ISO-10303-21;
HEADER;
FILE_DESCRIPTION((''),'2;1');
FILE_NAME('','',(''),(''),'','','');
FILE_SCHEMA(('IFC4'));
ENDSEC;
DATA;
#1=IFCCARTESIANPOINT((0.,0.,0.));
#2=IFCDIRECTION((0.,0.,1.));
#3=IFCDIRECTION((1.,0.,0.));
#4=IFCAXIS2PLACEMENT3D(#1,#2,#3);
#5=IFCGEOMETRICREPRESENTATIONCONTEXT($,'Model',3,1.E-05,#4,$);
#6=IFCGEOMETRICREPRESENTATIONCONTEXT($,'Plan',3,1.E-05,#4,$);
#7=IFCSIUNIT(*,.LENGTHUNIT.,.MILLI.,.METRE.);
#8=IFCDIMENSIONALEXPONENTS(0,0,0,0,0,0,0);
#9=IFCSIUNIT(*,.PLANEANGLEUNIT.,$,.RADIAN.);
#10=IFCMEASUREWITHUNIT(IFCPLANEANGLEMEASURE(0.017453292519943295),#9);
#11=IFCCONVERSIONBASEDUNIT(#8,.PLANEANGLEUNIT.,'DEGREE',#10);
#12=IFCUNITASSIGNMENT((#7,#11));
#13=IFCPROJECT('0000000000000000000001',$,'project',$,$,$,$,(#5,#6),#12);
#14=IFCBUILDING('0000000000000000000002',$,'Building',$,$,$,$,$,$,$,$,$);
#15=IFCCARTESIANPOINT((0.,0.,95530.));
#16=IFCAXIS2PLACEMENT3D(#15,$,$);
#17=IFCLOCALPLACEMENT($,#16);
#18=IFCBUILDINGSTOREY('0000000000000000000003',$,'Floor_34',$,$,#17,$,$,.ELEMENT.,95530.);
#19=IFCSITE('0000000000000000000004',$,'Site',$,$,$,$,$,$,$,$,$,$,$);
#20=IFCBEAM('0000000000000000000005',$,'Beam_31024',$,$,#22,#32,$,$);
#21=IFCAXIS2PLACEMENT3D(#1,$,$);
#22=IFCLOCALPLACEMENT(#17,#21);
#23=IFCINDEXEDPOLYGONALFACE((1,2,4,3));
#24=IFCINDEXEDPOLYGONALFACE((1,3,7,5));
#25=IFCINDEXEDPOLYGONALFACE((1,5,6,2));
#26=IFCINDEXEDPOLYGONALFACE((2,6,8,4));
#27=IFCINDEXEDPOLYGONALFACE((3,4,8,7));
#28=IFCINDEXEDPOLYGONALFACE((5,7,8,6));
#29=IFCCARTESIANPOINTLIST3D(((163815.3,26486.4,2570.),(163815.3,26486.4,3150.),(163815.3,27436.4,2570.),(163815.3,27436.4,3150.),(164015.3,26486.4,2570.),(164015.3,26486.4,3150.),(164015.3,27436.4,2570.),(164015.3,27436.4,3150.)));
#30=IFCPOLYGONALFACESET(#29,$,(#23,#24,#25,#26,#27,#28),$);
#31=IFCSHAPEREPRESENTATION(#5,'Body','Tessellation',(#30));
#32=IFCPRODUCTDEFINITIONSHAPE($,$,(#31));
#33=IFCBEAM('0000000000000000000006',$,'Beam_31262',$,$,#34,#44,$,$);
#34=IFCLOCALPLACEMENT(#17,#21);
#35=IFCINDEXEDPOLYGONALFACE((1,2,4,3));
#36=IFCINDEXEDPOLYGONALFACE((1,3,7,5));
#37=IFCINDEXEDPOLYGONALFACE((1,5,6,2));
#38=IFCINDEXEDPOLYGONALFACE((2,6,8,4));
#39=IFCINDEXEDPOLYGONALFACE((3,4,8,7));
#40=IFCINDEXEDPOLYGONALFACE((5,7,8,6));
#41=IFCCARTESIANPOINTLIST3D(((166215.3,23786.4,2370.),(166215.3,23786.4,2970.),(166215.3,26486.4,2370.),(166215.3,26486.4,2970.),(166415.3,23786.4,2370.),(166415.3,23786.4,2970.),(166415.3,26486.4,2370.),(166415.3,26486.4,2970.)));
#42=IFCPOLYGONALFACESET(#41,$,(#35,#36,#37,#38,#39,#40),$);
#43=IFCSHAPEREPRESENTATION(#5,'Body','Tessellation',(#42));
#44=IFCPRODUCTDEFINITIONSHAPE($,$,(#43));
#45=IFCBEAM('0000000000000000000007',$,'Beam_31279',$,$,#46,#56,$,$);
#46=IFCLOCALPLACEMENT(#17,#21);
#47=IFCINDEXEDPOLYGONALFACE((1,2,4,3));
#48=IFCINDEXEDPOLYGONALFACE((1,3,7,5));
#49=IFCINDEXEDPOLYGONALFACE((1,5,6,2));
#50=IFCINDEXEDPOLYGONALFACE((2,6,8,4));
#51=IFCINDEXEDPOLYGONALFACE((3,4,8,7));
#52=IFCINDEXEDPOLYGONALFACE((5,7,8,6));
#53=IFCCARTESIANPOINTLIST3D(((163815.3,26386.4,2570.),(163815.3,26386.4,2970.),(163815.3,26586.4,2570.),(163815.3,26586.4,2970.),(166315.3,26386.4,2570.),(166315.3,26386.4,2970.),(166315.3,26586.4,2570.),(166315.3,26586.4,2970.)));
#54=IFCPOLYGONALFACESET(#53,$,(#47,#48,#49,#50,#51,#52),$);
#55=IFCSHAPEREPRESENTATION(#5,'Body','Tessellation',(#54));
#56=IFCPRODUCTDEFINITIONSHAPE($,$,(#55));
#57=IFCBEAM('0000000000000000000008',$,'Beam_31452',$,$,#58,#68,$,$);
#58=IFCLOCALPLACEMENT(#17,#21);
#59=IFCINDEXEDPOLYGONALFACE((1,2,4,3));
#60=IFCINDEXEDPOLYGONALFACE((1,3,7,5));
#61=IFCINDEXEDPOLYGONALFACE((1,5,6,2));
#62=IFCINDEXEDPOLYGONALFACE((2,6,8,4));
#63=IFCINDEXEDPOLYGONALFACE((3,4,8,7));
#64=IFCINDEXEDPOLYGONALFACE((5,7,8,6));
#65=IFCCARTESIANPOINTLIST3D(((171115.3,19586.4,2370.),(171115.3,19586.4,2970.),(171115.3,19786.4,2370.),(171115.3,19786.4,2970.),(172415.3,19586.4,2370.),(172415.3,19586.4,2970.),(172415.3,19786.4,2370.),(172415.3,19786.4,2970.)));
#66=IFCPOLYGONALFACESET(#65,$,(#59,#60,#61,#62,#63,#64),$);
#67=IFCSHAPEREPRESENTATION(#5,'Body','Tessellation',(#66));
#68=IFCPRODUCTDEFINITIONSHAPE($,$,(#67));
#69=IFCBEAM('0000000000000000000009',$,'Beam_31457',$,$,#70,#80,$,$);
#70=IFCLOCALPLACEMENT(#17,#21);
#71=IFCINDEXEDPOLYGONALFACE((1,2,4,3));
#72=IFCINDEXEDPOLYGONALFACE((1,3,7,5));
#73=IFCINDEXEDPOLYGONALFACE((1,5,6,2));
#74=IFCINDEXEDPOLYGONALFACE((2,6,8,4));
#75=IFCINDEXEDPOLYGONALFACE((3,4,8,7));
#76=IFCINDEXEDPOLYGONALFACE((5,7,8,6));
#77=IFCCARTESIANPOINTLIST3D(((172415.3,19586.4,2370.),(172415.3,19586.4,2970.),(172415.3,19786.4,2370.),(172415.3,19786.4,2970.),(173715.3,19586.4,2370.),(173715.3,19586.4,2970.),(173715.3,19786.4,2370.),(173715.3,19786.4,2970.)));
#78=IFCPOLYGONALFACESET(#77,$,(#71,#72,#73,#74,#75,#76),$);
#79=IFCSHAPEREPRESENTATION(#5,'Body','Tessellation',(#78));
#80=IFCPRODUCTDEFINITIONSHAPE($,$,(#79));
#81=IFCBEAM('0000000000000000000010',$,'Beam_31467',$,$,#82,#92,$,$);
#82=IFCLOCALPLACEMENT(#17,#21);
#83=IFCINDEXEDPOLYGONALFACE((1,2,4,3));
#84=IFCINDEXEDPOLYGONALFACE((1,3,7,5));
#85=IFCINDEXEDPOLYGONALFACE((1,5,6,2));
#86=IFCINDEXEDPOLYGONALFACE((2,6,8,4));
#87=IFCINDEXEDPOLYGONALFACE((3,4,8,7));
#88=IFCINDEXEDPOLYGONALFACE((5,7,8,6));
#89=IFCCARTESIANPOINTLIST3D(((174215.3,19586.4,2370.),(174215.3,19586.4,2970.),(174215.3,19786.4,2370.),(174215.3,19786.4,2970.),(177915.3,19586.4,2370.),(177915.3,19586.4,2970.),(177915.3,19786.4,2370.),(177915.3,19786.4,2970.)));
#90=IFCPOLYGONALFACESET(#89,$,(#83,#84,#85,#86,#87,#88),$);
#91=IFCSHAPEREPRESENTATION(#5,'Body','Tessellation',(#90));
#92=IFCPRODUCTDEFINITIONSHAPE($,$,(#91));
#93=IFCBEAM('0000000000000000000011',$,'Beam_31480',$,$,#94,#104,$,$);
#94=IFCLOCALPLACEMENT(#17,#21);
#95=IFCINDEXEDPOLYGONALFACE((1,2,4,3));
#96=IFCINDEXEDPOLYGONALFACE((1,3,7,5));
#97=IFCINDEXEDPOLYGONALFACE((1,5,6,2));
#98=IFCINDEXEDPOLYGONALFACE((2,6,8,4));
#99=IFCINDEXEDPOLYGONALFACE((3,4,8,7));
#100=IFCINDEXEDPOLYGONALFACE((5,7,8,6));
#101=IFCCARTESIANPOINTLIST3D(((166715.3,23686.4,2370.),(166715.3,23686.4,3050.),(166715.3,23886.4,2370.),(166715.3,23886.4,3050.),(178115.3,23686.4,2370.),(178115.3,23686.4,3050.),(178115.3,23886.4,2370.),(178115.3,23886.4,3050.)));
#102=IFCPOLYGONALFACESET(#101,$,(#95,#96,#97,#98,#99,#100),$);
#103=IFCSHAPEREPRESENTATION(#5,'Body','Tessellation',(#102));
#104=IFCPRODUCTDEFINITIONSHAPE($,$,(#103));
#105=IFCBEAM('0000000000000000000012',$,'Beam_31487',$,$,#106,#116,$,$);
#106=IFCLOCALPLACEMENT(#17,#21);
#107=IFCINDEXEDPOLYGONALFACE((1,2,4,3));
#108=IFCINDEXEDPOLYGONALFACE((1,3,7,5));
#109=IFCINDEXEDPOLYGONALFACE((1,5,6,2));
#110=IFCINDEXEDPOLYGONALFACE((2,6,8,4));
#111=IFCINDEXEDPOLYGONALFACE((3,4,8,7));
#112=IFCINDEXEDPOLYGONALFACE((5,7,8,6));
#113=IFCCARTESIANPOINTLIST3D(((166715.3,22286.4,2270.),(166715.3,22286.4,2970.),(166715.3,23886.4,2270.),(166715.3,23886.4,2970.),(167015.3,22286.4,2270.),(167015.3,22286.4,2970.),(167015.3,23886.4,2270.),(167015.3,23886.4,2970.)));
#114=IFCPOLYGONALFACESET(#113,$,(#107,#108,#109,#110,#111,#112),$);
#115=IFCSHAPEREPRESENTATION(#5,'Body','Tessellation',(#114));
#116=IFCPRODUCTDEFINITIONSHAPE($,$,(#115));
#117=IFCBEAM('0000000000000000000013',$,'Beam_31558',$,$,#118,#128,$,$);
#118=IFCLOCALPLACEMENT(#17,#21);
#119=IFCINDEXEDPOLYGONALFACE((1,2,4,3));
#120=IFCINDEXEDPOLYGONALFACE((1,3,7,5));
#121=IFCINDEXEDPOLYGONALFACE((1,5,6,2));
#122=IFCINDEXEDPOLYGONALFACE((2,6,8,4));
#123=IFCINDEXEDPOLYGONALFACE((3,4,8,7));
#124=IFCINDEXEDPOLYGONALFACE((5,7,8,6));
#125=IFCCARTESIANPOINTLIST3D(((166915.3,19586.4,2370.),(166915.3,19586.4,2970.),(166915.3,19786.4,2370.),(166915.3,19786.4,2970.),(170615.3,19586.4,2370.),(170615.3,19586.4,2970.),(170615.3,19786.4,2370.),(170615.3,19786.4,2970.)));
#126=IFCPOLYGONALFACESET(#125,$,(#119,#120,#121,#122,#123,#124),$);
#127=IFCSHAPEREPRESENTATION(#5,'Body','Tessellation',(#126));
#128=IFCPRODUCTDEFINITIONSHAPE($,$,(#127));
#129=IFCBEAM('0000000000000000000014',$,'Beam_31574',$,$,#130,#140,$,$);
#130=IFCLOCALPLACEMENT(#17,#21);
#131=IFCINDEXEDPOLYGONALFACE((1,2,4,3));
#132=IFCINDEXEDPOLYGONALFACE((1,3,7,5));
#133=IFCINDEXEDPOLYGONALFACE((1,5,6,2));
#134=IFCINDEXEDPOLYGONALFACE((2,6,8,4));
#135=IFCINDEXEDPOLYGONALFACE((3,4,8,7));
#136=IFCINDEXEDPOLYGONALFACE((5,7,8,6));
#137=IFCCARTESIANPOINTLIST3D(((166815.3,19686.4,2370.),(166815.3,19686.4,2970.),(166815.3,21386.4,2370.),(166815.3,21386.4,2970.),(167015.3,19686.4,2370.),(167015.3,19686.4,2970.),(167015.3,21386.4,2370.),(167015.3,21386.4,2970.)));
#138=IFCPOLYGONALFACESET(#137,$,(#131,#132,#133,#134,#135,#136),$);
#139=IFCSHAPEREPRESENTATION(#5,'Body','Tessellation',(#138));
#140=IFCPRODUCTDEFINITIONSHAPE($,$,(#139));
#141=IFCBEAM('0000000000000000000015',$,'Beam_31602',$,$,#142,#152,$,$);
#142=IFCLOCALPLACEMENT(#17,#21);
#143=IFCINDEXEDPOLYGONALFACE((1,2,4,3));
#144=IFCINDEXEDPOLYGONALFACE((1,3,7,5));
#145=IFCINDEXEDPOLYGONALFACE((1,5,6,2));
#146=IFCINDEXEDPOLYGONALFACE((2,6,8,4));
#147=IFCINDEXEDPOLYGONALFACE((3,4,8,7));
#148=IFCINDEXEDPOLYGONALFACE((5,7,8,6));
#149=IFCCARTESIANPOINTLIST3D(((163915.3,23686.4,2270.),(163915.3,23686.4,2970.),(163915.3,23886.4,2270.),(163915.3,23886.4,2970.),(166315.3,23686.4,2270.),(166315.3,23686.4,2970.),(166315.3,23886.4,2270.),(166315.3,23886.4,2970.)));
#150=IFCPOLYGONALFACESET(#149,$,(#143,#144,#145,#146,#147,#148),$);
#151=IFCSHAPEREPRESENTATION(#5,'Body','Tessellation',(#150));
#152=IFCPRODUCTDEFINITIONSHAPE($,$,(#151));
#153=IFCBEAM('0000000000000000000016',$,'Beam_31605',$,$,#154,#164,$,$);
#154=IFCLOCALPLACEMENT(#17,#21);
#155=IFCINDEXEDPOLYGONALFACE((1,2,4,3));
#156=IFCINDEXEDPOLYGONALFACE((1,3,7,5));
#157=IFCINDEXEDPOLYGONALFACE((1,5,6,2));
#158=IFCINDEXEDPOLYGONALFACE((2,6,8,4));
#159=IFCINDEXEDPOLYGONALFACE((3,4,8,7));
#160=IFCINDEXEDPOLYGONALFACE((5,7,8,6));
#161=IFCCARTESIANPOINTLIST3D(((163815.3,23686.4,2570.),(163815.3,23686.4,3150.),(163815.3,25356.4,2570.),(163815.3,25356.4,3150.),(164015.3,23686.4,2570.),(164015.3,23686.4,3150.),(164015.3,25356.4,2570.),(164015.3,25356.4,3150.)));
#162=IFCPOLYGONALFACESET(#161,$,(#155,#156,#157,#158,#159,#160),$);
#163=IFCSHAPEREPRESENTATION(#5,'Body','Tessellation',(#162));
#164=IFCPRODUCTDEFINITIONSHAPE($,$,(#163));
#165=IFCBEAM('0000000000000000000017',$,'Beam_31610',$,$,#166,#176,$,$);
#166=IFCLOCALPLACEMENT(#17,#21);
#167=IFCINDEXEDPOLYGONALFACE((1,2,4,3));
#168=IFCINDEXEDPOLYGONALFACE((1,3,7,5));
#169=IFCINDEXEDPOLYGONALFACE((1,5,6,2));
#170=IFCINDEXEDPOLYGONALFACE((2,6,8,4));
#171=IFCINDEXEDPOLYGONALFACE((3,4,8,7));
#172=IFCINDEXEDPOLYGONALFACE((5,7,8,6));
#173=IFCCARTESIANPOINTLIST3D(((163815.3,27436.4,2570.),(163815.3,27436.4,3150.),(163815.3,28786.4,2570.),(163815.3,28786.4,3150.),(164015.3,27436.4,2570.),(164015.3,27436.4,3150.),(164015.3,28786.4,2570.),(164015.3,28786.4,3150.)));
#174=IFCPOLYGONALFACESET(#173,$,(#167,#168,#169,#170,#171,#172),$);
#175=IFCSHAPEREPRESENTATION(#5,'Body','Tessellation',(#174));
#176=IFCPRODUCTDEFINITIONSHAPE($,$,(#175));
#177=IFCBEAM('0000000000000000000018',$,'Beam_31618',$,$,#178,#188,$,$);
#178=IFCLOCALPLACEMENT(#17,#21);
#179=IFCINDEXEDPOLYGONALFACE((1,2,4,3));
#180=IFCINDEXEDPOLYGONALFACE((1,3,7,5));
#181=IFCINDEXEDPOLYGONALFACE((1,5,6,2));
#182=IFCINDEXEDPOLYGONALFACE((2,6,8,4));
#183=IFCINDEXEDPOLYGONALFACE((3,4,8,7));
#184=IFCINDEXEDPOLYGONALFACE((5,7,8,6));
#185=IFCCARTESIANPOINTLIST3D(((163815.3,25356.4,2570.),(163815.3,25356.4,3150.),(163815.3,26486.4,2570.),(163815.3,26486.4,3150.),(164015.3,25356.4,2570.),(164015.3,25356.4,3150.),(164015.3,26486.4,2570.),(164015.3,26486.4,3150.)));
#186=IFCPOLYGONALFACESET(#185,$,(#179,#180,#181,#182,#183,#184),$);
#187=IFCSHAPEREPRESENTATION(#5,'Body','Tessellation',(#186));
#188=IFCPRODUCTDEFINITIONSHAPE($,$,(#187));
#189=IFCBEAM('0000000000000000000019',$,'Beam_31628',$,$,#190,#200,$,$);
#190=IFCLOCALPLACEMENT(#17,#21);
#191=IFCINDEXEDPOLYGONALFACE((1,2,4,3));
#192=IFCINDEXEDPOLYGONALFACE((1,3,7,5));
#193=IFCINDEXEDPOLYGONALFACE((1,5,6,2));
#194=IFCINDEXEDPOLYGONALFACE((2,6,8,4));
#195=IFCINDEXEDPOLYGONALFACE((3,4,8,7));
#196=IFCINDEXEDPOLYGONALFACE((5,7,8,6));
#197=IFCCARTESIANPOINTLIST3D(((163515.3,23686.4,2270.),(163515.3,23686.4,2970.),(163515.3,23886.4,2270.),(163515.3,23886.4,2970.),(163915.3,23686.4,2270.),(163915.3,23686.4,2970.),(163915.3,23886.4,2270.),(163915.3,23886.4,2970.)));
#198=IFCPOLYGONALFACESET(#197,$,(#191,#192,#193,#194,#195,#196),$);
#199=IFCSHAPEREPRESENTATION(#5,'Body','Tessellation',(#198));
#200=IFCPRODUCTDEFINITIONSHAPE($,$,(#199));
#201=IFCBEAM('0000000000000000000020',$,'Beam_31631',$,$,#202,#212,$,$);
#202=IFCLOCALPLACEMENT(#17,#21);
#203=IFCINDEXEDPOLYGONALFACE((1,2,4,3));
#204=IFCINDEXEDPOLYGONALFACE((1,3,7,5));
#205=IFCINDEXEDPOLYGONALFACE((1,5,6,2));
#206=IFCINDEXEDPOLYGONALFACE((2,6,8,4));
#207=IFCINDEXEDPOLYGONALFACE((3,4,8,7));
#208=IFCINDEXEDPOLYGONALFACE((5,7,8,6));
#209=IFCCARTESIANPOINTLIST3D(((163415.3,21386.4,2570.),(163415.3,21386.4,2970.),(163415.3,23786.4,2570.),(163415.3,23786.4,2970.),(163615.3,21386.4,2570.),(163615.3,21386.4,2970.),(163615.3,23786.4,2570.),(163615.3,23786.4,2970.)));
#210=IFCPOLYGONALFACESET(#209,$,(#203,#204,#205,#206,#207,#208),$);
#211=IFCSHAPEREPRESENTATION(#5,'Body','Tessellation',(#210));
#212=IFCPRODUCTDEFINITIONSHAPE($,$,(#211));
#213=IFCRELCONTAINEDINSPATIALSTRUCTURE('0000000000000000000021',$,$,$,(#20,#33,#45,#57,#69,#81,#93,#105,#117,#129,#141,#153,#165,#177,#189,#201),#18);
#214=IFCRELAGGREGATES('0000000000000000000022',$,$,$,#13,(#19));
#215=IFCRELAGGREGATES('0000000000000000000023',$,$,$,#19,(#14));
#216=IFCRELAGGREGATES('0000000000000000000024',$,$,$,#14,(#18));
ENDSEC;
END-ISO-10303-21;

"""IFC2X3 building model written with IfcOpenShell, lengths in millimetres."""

from ifc_helpers import new_model, entity, si_unit, converted_unit, frame, origin_with_axes, origin_2d, place, context, project, spatial, rectangle, extrude, element, save


model = new_model("IFC2X3")

# Units and contexts
model_context = context("Model", 3, precision=1e-05, world=origin_with_axes())
plan_context = context("Plan", 3, precision=1e-05, world=origin_with_axes())
ifc_project = project(units=[si_unit("LENGTHUNIT", "METRE", prefix="MILLI"), converted_unit("PLANEANGLEUNIT", "DEGREE", entity("IfcPlaneAngleMeasure", 0.017453292519943295), si_unit("PLANEANGLEUNIT", "RADIAN"), dimensions=[0, 0, 0, 0, 0, 0, 0])], contexts=[model_context, plan_context])

# Site, building, storey
site = spatial("IfcSite", under=ifc_project, Name="Site")
building = spatial("IfcBuilding", under=site, Name="Building")
storey_placement = place(None, frame((0.0, 0.0, 95530.0)))
storey = spatial("IfcBuildingStorey", under=building, at=storey_placement, Name="Floor_34", CompositionType="ELEMENT", Elevation=95530.0)

# Beams
beam_1_placement = place(storey_placement, frame((163915.3, 26486.4, 2860.0), z_axis=(0.0, 950.0, 0.0), x_axis=(950.0, 0.0, 0.0)))
element("IfcBeam", 1, at=beam_1_placement, inside=storey, Name="Beam_31024", context=model_context, shape_type="SweptSolid", body=[
    extrude(rectangle(XDim=200.0, YDim=580.0, at=origin_2d()), origin_with_axes(), (0.0, 0.0, 1.0), 950.0),
])
beam_2_placement = place(storey_placement, frame((166315.3, 23786.4, 2670.0), z_axis=(0.0, 2699.999995, 0.0), x_axis=(2699.999995, 0.0, 0.0)))
element("IfcBeam", 2, at=beam_2_placement, inside=storey, Name="Beam_31262", context=model_context, shape_type="SweptSolid", body=[
    extrude(rectangle(XDim=200.0, YDim=600.0, at=origin_2d()), origin_with_axes(), (0.0, 0.0, 1.0), 2700.0),
])
beam_3_placement = place(storey_placement, frame((163815.3, 26486.4, 2770.0), z_axis=(2500.0, 0.0, 0.0), x_axis=(0.0, -2500.0, 0.0)))
element("IfcBeam", 3, at=beam_3_placement, inside=storey, Name="Beam_31279", context=model_context, shape_type="SweptSolid", body=[
    extrude(rectangle(XDim=200.0, YDim=400.0, at=origin_2d()), origin_with_axes(), (0.0, 0.0, 1.0), 2500.0),
])
for number, where, z_axis, x_axis, name in (
    (4, (171115.3, 19686.4, 2670.0), (1300.000018, 0.0, 0.0), (0.0, -1300.000018, 0.0), "Beam_31452"),
    (5, (172415.3, 19686.4, 2670.0), (1300.000018, 0.0, 0.0), (0.0, -1300.000018, 0.0), "Beam_31457"),
):
    element("IfcBeam", number, at=place(storey_placement, frame(where, z_axis=z_axis, x_axis=x_axis)), inside=storey, Name=name, context=model_context, shape_type="SweptSolid", body=[
        extrude(rectangle(XDim=200.0, YDim=600.0, at=origin_2d()), origin_with_axes(), (0.0, 0.0, 1.0), 1300.0),
    ])
beam_4_placement = place(storey_placement, frame((174215.3, 19686.4, 2670.0), z_axis=(3700.00003, 0.0, 0.0), x_axis=(0.0, -3700.00003, 0.0)))
element("IfcBeam", 6, at=beam_4_placement, inside=storey, Name="Beam_31467", context=model_context, shape_type="SweptSolid", body=[
    extrude(rectangle(XDim=200.0, YDim=600.0, at=origin_2d()), origin_with_axes(), (0.0, 0.0, 1.0), 3700.0),
])
beam_5_placement = place(storey_placement, frame((166715.3, 23786.4, 2710.0), z_axis=(11399.999785, 0.0, 0.0), x_axis=(0.0, -11399.999785, 0.0)))
element("IfcBeam", 7, at=beam_5_placement, inside=storey, Name="Beam_31480", context=model_context, shape_type="SweptSolid", body=[
    extrude(rectangle(XDim=200.0, YDim=680.0, at=origin_2d()), origin_with_axes(), (0.0, 0.0, 1.0), 11400.0),
])
beam_6_placement = place(storey_placement, frame((166865.3, 22286.4, 2620.0), z_axis=(0.0, 1600.000005, 0.0), x_axis=(1600.000005, 0.0, 0.0)))
element("IfcBeam", 8, at=beam_6_placement, inside=storey, Name="Beam_31487", context=model_context, shape_type="SweptSolid", body=[
    extrude(rectangle(XDim=300.0, YDim=700.0, at=origin_2d()), origin_with_axes(), (0.0, 0.0, 1.0), 1600.0),
])
beam_7_placement = place(storey_placement, frame((166915.3, 19686.4, 2670.0), z_axis=(3699.999953, 0.0, 0.0), x_axis=(0.0, -3699.999953, 0.0)))
element("IfcBeam", 9, at=beam_7_placement, inside=storey, Name="Beam_31558", context=model_context, shape_type="SweptSolid", body=[
    extrude(rectangle(XDim=200.0, YDim=600.0, at=origin_2d()), origin_with_axes(), (0.0, 0.0, 1.0), 3700.0),
])
beam_8_placement = place(storey_placement, frame((166915.3, 19686.4, 2670.0), z_axis=(0.000079, 1699.979151, 0.0), x_axis=(1699.979151, -0.000079, 0.0)))
element("IfcBeam", 10, at=beam_8_placement, inside=storey, Name="Beam_31574", context=model_context, shape_type="SweptSolid", body=[
    extrude(rectangle(XDim=200.0, YDim=600.0, at=origin_2d()), origin_with_axes(), (0.0, 0.0, 1.0), 1700.0),
])
beam_9_placement = place(storey_placement, frame((163915.3, 23786.4, 2620.0), z_axis=(2400.0, 0.0, 0.0), x_axis=(0.0, -2400.0, 0.0)))
element("IfcBeam", 11, at=beam_9_placement, inside=storey, Name="Beam_31602", context=model_context, shape_type="SweptSolid", body=[
    extrude(rectangle(XDim=200.0, YDim=700.0, at=origin_2d()), origin_with_axes(), (0.0, 0.0, 1.0), 2400.0),
])
beam_10_placement = place(storey_placement, frame((163915.3, 23686.4, 2860.0), z_axis=(0.0, 1669.999995, 0.0), x_axis=(1669.999995, 0.0, 0.0)))
element("IfcBeam", 12, at=beam_10_placement, inside=storey, Name="Beam_31605", context=model_context, shape_type="SweptSolid", body=[
    extrude(rectangle(XDim=200.0, YDim=580.0, at=origin_2d()), origin_with_axes(), (0.0, 0.0, 1.0), 1670.0),
])
beam_11_placement = place(storey_placement, frame((163915.3, 27436.4, 2860.0), z_axis=(0.0, 1350.0, 0.0), x_axis=(1350.0, 0.0, 0.0)))
element("IfcBeam", 13, at=beam_11_placement, inside=storey, Name="Beam_31610", context=model_context, shape_type="SweptSolid", body=[
    extrude(rectangle(XDim=200.0, YDim=580.0, at=origin_2d()), origin_with_axes(), (0.0, 0.0, 1.0), 1350.0),
])
beam_12_placement = place(storey_placement, frame((163915.3, 25356.4, 2860.0), z_axis=(0.0, 1130.0, 0.0), x_axis=(1130.0, 0.0, 0.0)))
element("IfcBeam", 14, at=beam_12_placement, inside=storey, Name="Beam_31618", context=model_context, shape_type="SweptSolid", body=[
    extrude(rectangle(XDim=200.0, YDim=580.0, at=origin_2d()), origin_with_axes(), (0.0, 0.0, 1.0), 1130.0),
])
beam_13_placement = place(storey_placement, frame((163515.3, 23786.4, 2620.0), z_axis=(400.000001, 0.0, 0.0), x_axis=(0.0, -400.000001, 0.0)))
element("IfcBeam", 15, at=beam_13_placement, inside=storey, Name="Beam_31628", context=model_context, shape_type="SweptSolid", body=[
    extrude(rectangle(XDim=200.0, YDim=700.0, at=origin_2d()), origin_with_axes(), (0.0, 0.0, 1.0), 400.0),
])
beam_14_placement = place(storey_placement, frame((163515.3, 21386.4, 2770.0), z_axis=(0.0, 2400.0, 0.0), x_axis=(2400.0, 0.0, 0.0)))
element("IfcBeam", 16, at=beam_14_placement, inside=storey, Name="Beam_31631", context=model_context, shape_type="SweptSolid", body=[
    extrude(rectangle(XDim=200.0, YDim=400.0, at=origin_2d()), origin_with_axes(), (0.0, 0.0, 1.0), 2400.0),
])

save(model, "model.ifc")
